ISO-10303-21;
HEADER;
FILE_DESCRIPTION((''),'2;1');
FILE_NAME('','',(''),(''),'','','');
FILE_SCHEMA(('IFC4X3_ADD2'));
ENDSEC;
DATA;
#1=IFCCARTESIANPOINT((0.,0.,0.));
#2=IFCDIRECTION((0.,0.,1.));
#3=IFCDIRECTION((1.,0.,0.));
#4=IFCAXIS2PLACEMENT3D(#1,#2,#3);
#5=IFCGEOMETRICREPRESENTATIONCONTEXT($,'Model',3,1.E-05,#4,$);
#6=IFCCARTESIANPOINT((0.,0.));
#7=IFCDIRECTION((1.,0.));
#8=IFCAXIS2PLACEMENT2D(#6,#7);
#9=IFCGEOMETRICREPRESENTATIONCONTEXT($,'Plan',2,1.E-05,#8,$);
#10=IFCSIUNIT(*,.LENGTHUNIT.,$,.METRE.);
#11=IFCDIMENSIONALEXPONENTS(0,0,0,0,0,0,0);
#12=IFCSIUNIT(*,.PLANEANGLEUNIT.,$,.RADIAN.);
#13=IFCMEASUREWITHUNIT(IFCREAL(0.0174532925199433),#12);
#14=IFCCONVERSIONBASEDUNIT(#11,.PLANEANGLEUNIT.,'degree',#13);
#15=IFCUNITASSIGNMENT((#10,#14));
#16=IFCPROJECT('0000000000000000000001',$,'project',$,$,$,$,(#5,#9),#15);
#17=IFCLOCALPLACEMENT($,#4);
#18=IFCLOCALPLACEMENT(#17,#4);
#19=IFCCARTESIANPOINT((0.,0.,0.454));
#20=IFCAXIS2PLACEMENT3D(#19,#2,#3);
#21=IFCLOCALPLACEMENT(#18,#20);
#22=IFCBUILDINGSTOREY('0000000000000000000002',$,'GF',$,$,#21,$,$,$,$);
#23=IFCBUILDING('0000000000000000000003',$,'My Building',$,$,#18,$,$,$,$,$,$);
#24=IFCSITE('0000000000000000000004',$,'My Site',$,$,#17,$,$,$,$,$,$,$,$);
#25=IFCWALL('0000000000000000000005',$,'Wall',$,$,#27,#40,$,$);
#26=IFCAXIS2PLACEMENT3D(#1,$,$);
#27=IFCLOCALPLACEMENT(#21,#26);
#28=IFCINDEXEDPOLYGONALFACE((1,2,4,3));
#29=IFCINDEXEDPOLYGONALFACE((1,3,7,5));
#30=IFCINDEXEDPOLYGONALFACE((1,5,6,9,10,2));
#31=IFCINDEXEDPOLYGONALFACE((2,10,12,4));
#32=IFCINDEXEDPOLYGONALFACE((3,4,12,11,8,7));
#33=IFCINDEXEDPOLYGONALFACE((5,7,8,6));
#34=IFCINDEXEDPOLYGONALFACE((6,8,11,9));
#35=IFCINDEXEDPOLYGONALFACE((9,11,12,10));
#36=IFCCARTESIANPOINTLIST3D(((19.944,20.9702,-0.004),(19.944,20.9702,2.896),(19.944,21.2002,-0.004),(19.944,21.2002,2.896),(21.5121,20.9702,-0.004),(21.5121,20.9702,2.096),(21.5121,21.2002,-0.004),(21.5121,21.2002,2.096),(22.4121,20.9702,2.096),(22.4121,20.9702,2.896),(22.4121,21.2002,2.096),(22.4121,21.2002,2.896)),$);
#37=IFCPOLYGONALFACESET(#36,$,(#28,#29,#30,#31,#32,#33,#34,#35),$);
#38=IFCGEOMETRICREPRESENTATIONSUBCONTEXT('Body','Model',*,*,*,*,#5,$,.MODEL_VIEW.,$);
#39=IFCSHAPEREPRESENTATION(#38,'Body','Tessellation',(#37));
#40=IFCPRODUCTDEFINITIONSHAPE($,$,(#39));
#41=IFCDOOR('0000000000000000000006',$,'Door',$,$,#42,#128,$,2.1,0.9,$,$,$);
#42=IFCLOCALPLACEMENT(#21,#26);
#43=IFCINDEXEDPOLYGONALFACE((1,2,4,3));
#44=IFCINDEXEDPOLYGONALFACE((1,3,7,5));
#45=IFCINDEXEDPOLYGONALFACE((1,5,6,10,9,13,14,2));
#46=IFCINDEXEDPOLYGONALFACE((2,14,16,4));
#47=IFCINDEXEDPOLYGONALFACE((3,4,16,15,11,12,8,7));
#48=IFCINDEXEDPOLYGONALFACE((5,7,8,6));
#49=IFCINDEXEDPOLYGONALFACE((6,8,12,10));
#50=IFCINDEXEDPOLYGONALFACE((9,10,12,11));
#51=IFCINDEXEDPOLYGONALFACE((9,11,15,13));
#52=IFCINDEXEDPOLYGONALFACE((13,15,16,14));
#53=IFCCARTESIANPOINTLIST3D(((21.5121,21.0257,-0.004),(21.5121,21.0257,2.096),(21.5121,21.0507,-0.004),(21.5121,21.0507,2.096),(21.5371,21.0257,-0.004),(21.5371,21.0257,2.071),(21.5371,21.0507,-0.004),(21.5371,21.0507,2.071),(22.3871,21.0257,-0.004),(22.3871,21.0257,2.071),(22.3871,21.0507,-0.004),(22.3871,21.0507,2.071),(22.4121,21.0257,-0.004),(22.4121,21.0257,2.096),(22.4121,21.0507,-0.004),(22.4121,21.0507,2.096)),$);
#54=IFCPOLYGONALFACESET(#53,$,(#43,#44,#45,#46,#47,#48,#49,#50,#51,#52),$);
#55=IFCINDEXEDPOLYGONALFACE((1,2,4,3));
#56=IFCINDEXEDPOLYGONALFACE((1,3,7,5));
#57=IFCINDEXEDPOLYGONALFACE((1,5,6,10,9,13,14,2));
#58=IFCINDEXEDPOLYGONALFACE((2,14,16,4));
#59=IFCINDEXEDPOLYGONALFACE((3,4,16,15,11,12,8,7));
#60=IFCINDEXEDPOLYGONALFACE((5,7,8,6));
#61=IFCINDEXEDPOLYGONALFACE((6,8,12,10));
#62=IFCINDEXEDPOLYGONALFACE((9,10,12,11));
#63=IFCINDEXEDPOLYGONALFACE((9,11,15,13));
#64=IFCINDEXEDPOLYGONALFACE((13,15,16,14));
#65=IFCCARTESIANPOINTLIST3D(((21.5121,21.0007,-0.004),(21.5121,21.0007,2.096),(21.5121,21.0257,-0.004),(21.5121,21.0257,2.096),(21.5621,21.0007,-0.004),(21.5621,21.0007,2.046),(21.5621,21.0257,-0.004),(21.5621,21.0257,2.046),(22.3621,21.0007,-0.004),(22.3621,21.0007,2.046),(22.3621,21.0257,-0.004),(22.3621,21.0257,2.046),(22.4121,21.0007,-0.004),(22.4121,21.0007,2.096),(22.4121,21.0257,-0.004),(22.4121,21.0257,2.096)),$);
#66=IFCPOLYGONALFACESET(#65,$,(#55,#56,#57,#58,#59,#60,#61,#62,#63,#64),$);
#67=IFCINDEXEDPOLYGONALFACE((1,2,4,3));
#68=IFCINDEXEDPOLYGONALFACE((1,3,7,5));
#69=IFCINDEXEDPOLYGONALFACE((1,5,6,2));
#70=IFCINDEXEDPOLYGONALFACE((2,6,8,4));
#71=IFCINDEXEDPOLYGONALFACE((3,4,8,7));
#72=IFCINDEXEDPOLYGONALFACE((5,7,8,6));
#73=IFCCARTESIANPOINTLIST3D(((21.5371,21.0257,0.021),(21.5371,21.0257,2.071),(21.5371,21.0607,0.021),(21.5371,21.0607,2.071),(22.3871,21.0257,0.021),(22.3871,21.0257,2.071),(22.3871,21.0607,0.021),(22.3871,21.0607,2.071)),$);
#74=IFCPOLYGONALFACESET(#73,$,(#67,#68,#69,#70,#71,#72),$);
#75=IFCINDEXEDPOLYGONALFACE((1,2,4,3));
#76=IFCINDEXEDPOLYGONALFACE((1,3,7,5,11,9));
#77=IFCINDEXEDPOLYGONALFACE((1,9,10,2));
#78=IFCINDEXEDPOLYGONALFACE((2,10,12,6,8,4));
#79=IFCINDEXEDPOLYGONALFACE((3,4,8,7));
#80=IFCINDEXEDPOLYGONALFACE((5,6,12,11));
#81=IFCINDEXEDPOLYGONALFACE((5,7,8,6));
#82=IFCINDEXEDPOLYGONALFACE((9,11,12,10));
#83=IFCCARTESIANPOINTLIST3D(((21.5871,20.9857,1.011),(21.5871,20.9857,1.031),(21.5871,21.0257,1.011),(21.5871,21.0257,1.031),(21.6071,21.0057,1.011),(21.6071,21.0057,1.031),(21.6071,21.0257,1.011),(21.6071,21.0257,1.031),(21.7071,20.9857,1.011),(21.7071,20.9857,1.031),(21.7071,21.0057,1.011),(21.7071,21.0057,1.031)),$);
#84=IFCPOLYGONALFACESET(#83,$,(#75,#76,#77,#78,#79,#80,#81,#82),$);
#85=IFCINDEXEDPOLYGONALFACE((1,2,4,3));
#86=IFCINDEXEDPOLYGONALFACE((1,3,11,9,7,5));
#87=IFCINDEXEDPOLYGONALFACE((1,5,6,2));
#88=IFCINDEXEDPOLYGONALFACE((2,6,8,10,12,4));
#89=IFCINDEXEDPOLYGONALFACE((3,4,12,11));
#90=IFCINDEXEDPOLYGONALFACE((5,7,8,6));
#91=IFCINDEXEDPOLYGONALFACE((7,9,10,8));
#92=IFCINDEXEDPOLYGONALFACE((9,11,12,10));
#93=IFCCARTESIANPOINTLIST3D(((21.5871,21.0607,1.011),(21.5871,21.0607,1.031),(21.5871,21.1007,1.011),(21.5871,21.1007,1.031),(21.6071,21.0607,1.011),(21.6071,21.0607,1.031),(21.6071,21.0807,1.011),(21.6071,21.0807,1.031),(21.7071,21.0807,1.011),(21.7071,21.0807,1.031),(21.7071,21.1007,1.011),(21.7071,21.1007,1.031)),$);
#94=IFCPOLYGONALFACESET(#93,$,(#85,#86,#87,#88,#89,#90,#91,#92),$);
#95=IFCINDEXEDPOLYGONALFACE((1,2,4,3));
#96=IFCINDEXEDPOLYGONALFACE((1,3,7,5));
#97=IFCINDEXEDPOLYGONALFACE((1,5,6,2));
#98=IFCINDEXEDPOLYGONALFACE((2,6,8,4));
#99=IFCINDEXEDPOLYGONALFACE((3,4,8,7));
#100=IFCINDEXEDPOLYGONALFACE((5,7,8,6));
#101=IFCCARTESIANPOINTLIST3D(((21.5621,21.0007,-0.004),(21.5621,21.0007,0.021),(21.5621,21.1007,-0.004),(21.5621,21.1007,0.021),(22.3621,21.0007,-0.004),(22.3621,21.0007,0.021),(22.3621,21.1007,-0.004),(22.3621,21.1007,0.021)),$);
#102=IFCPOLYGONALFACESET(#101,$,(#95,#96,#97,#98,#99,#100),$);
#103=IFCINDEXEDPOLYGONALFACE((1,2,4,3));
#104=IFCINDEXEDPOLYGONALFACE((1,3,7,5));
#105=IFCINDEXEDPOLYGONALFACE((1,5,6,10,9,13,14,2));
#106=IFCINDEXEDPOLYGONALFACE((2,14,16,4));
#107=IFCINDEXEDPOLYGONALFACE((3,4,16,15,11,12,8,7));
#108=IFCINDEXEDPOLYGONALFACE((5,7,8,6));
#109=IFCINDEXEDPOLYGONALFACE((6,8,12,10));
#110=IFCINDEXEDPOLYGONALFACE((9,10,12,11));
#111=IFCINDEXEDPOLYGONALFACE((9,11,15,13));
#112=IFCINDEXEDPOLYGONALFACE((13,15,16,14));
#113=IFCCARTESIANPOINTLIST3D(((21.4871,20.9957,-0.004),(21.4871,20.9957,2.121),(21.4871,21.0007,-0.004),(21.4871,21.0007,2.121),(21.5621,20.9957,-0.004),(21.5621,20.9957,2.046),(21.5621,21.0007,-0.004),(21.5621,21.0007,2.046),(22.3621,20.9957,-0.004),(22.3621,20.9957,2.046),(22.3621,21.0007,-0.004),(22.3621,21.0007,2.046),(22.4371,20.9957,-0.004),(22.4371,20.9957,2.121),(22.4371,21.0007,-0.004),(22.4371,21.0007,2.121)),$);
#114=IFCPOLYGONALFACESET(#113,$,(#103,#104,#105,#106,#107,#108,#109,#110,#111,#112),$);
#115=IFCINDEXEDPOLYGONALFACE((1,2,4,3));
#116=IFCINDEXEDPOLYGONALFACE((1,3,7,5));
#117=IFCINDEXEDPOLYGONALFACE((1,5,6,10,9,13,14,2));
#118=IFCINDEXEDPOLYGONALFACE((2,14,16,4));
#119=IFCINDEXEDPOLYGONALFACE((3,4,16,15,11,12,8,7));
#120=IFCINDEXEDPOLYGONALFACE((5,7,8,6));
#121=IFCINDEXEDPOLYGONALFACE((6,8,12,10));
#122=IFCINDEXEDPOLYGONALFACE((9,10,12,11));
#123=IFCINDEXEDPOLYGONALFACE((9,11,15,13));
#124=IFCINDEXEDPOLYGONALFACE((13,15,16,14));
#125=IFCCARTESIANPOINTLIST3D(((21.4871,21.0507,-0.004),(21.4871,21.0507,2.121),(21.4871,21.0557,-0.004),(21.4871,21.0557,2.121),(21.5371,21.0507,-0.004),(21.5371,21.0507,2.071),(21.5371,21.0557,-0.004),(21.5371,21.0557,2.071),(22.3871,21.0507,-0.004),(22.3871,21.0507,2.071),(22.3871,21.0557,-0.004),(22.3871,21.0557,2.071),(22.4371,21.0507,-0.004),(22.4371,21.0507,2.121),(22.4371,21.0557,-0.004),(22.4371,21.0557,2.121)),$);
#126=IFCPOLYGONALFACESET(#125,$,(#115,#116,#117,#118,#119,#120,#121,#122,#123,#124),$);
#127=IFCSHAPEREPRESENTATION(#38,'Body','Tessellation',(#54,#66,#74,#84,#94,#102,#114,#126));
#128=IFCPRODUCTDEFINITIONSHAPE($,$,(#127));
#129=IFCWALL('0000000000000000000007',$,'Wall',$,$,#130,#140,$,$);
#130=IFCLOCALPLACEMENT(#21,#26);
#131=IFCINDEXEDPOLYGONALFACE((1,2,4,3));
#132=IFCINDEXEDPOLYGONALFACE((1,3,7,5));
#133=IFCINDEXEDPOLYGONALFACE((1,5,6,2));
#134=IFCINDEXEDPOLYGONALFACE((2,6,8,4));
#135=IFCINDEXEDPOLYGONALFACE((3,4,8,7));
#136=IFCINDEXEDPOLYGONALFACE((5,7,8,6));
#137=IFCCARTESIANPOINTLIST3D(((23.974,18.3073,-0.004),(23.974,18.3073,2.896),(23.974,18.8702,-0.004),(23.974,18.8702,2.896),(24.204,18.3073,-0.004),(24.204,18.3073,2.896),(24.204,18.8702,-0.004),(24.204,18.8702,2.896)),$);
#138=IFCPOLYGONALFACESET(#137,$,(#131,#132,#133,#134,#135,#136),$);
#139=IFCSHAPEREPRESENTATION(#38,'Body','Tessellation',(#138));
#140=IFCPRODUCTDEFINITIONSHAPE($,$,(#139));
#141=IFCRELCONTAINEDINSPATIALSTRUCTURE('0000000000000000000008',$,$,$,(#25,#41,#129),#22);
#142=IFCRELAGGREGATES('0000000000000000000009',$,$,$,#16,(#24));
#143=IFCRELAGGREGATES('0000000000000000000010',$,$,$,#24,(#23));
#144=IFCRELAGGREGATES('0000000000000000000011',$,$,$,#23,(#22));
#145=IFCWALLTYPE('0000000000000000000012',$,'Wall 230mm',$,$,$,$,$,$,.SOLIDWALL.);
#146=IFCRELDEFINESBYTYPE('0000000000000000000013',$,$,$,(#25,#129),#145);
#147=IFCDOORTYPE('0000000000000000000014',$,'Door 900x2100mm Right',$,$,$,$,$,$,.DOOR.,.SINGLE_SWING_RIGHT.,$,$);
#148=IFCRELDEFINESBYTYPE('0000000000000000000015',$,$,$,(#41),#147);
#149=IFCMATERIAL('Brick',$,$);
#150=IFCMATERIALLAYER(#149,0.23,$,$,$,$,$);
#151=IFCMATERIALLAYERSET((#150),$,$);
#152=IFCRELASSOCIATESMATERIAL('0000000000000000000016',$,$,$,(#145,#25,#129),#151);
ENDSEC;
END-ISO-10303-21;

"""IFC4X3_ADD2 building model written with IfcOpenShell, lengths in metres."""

from ifc_helpers import new_model, entity, si_unit, converted_unit, frame, origin_with_axes, origin_2d_with_axis, place, context, subcontext, project, spatial, line, indexed_curve, outline, extrude, shape, source, transform, mapped, material, layer, layer_set, layer_usage, type_object, type_shapes, element, fill, save


model = new_model("IFC4X3_ADD2")

# Units and contexts
model_context = context("Model", 3, precision=1e-05, world=origin_with_axes())
plan_context = context("Plan", 2, precision=1e-05, world=origin_2d_with_axis())
body_context_1 = subcontext(model_context, "Body", "Model", "MODEL_VIEW")
body_context_2 = subcontext(plan_context, "Body", "Plan", "PLAN_VIEW")
ifc_project = project(units=[si_unit("LENGTHUNIT", "METRE"), converted_unit("PLANEANGLEUNIT", "degree", entity("IfcReal", 0.0174532925199433), si_unit("PLANEANGLEUNIT", "RADIAN"), dimensions=[0, 0, 0, 0, 0, 0, 0])], contexts=[model_context, plan_context])

# Site, building, storey
site_placement = place(None, origin_with_axes())
site = spatial("IfcSite", under=ifc_project, at=site_placement, Name="My Site")
building_placement = place(site_placement, origin_with_axes())
building = spatial("IfcBuilding", under=site, at=building_placement, Name="My Building")
storey_placement = place(building_placement, frame((0.0, 0.0, 0.454), z_axis=(0.0, 0.0, 1.0), x_axis=(1.0, 0.0, 0.0)))
storey = spatial("IfcBuildingStorey", under=building, at=storey_placement, Name="GF")

# Shared definitions
ifc_material_1 = material(Name="Brick")
ifc_layer_1 = layer(ifc_material_1, 0.23)
ifc_layer_set_1 = layer_set([ifc_layer_1])
wall_type = type_object("IfcWallType", Name="Wall 230mm", PredefinedType="SOLIDWALL", material=ifc_layer_set_1)

# Wall, opening, door
ifc_layer_usage_1 = layer_usage(ifc_layer_set_1, "AXIS2", "POSITIVE", 0.0)
wall_1_placement = place(storey_placement, frame((22.4121, 21.2002, -0.004), z_axis=(0.0, 0.0, 1.0), x_axis=(-1.0, 0.0, 0.0)))
wall_1 = element("IfcWall", 1, at=wall_1_placement, inside=storey, type_object=wall_type, material=ifc_layer_usage_1, Name="Wall", context=body_context_1, shape_type="SweptSolid", body=[
    extrude(outline(indexed_curve([(0.0, 0.0), (0.0, 0.23), (2.4681, 0.23), (2.4681, 0.0), (0.0, 0.0)], self_intersect=False)), origin_with_axes(), (0.0, 0.0, 1.0), 2.9),
])
shared_shape_1 = source(origin_with_axes(), body_context_1, "Body", "SweptSolid", [
    extrude(outline(indexed_curve([(0.0, 0.0), (0.9, 0.0), (0.9, 2.1), (0.0, 2.1)], segments=[line(1, 2, 3, 4, 1)])), frame((0.0, -0.6, 0.0), z_axis=(0.0, -1.0, 0.0), x_axis=(1.0, 0.0, 0.0)), (0.0, 0.0, -1.0), 1.2),
])
opening_1_placement = place(wall_1_placement, frame((0.9, 0.1995, 0.0), z_axis=(0.0, 0.0, 1.0), x_axis=(-1.0, 0.0, 0.0)))
opening_1 = element("IfcOpeningElement", 2, at=opening_1_placement, cuts=wall_1, PredefinedType="OPENING", context=body_context_1, shape_type="MappedRepresentation", body=[
    mapped(shared_shape_1, transform((0.0, 0.0, 0.0), x_axis=(1.0, 0.0, 0.0), y_axis=(0.0, 1.0, 0.0), z_axis=(0.0, 0.0, 1.0), scale=1.0)),
])
door_type_1 = type_object("IfcDoorType", Name="Door 900x2100mm Right", OperationType="SINGLE_SWING_RIGHT", PredefinedType="DOOR")
shared_shape_2 = source(origin_with_axes(), body_context_1, "Body", "SweptSolid", [
    extrude(outline(indexed_curve([(0.0, 0.0), (0.0, 2.1), (0.9, 2.1), (0.9, 0.0), (0.875, 0.0), (0.875, 2.075), (0.025, 2.075), (0.025, 0.0)], segments=[line(1, 2, 3, 4, 5, 6, 7, 8, 1)])), frame((0.0, 0.025, 0.0), z_axis=(0.0, -1.0, 0.0), x_axis=(1.0, 0.0, 0.0)), (0.0, 0.0, -1.0), 0.025),
    extrude(outline(indexed_curve([(0.0, 0.0), (0.0, 2.1), (0.9, 2.1), (0.9, 0.0), (0.85, 0.0), (0.85, 2.05), (0.05, 2.05), (0.05, 0.0)], segments=[line(1, 2, 3, 4, 5, 6, 7, 8, 1)])), frame((0.0, 0.0, 0.0), z_axis=(0.0, -1.0, 0.0), x_axis=(1.0, 0.0, 0.0)), (0.0, 0.0, -1.0), 0.025),
    extrude(outline(indexed_curve([(0.0, 0.0), (0.85, 0.0), (0.85, 0.035), (0.0, 0.035)], segments=[line(1, 2, 3, 4, 1)])), frame((0.025, 0.025, 0.025), z_axis=(0.0, 0.0, 1.0), x_axis=(1.0, 0.0, 0.0)), (0.0, 0.0, 1.0), 2.05),
    extrude(outline(indexed_curve([(0.0, 0.0), (0.0, -0.04), (0.12, -0.04), (0.12, -0.02), (0.02, -0.02), (0.02, 0.0)], segments=[line(1, 2, 3, 4, 5, 6, 1)])), frame((0.075, 0.025, 1.015), z_axis=(0.0, 0.0, 1.0), x_axis=(1.0, 0.0, 0.0)), (0.0, 0.0, 1.0), 0.02),
    extrude(outline(indexed_curve([(0.0, 0.0), (0.0, 0.04), (0.12, 0.04), (0.12, 0.02), (0.02, 0.02), (0.02, 0.0)], segments=[line(1, 2, 3, 4, 5, 6, 1)])), frame((0.075, 0.06, 1.015), z_axis=(0.0, 0.0, 1.0), x_axis=(1.0, 0.0, 0.0)), (0.0, 0.0, 1.0), 0.02),
    extrude(outline(indexed_curve([(0.0, 0.0), (0.8, 0.0), (0.8, 0.1), (0.0, 0.1)], segments=[line(1, 2, 3, 4, 1)])), frame((0.05, 0.0, 0.0), z_axis=(0.0, 0.0, 1.0), x_axis=(1.0, 0.0, 0.0)), (0.0, 0.0, 1.0), 0.025),
    extrude(outline(indexed_curve([(0.0, 0.0), (0.0, 2.125), (0.95, 2.125), (0.95, 0.0), (0.875, 0.0), (0.875, 2.05), (0.075, 2.05), (0.075, 0.0)], segments=[line(1, 2, 3, 4, 5, 6, 7, 8, 1)])), frame((-0.025, -0.005, 0.0), z_axis=(0.0, -1.0, 0.0), x_axis=(1.0, 0.0, 0.0)), (0.0, 0.0, -1.0), 0.005),
    extrude(outline(indexed_curve([(0.0, 0.0), (0.0, 2.125), (0.95, 2.125), (0.95, 0.0), (0.9, 0.0), (0.9, 2.075), (0.05, 2.075), (0.05, 0.0)], segments=[line(1, 2, 3, 4, 5, 6, 7, 8, 1)])), frame((-0.025, 0.05, 0.0), z_axis=(0.0, -1.0, 0.0), x_axis=(1.0, 0.0, 0.0)), (0.0, 0.0, -1.0), 0.005),
])
shared_shape_3 = source(origin_with_axes(), body_context_2, "Body", "Curve2D", [
    entity("IfcIndexedPolyCurve", entity("IfcCartesianPointList2D", [[0.0, 0.0], [0.0, 0.05], [0.025, 0.05], [0.025, 0.025], [0.05, 0.025], [0.05, 0.0]]), [entity("IfcLineIndex", [1, 2, 3, 4, 5, 6, 1])]),
    entity("IfcIndexedPolyCurve", entity("IfcCartesianPointList2D", [[0.9, 0.0], [0.9, 0.05], [0.875, 0.05], [0.875, 0.025], [0.85, 0.025], [0.85, 0.0]]), [entity("IfcLineIndex", [1, 2, 3, 4, 5, 6, 1])]),
    entity("IfcTrimmedCurve", entity("IfcEllipse", entity("IfcAxis2Placement2D", entity("IfcCartesianPoint", [0.84, 0.05]), entity("IfcDirection", [1.0, 0.0])), 0.815, 0.85), [entity("IfcCartesianPoint", [0.84, 0.9])], [entity("IfcCartesianPoint", [0.025, 0.05])], True, "CARTESIAN"),
    entity("IfcIndexedPolyCurve", entity("IfcCartesianPointList2D", [[0.875, 0.05], [0.84, 0.05], [0.84, 0.9], [0.875, 0.9]]), [entity("IfcLineIndex", [1, 2, 3, 4, 1])]),
])
type_shapes(door_type_1, [shared_shape_2, shared_shape_3])
door_1_placement = place(opening_1_placement, frame((0.0, 0.0, 0.0), z_axis=(0.0, 0.0, 1.0), x_axis=(1.0, 0.0, 0.0)))
door_1 = element("IfcDoor", 3, at=door_1_placement, inside=storey, type_object=door_type_1, Name="Door", OverallHeight=2.1, OverallWidth=0.9, shapes=[
    shape(body_context_1, "Body", "MappedRepresentation", [mapped(shared_shape_2, transform((0.0, 0.0, 0.0), x_axis=(1.0, 0.0, 0.0), y_axis=(0.0, 1.0, 0.0), z_axis=(0.0, 0.0, 1.0), scale=1.0))]),
    shape(body_context_2, "Body", "MappedRepresentation", [mapped(shared_shape_3, transform((0.0, 0.0, 0.0), x_axis=(1.0, 0.0, 0.0), y_axis=(0.0, 1.0, 0.0), z_axis=(0.0, 0.0, 1.0), scale=1.0))]),
])
fill(opening_1, door_1)

# Wall
ifc_layer_usage_2 = layer_usage(ifc_layer_set_1, "AXIS2", "POSITIVE", 0.0)
wall_2_placement = place(storey_placement, frame((24.204, 18.3073, -0.004), z_axis=(0.0, 0.0, 1.0), x_axis=(0.000001, 1.0, 0.0)))
element("IfcWall", 4, at=wall_2_placement, inside=storey, type_object=wall_type, material=ifc_layer_usage_2, Name="Wall", context=body_context_1, shape_type="SweptSolid", body=[
    extrude(outline(indexed_curve([(0.0, 0.0), (0.0, 0.23), (0.5629, 0.23), (0.5629, 0.0), (0.0, 0.0)], self_intersect=False)), origin_with_axes(), (0.0, 0.0, 1.0), 2.9),
])

save(model, "model.ifc")
